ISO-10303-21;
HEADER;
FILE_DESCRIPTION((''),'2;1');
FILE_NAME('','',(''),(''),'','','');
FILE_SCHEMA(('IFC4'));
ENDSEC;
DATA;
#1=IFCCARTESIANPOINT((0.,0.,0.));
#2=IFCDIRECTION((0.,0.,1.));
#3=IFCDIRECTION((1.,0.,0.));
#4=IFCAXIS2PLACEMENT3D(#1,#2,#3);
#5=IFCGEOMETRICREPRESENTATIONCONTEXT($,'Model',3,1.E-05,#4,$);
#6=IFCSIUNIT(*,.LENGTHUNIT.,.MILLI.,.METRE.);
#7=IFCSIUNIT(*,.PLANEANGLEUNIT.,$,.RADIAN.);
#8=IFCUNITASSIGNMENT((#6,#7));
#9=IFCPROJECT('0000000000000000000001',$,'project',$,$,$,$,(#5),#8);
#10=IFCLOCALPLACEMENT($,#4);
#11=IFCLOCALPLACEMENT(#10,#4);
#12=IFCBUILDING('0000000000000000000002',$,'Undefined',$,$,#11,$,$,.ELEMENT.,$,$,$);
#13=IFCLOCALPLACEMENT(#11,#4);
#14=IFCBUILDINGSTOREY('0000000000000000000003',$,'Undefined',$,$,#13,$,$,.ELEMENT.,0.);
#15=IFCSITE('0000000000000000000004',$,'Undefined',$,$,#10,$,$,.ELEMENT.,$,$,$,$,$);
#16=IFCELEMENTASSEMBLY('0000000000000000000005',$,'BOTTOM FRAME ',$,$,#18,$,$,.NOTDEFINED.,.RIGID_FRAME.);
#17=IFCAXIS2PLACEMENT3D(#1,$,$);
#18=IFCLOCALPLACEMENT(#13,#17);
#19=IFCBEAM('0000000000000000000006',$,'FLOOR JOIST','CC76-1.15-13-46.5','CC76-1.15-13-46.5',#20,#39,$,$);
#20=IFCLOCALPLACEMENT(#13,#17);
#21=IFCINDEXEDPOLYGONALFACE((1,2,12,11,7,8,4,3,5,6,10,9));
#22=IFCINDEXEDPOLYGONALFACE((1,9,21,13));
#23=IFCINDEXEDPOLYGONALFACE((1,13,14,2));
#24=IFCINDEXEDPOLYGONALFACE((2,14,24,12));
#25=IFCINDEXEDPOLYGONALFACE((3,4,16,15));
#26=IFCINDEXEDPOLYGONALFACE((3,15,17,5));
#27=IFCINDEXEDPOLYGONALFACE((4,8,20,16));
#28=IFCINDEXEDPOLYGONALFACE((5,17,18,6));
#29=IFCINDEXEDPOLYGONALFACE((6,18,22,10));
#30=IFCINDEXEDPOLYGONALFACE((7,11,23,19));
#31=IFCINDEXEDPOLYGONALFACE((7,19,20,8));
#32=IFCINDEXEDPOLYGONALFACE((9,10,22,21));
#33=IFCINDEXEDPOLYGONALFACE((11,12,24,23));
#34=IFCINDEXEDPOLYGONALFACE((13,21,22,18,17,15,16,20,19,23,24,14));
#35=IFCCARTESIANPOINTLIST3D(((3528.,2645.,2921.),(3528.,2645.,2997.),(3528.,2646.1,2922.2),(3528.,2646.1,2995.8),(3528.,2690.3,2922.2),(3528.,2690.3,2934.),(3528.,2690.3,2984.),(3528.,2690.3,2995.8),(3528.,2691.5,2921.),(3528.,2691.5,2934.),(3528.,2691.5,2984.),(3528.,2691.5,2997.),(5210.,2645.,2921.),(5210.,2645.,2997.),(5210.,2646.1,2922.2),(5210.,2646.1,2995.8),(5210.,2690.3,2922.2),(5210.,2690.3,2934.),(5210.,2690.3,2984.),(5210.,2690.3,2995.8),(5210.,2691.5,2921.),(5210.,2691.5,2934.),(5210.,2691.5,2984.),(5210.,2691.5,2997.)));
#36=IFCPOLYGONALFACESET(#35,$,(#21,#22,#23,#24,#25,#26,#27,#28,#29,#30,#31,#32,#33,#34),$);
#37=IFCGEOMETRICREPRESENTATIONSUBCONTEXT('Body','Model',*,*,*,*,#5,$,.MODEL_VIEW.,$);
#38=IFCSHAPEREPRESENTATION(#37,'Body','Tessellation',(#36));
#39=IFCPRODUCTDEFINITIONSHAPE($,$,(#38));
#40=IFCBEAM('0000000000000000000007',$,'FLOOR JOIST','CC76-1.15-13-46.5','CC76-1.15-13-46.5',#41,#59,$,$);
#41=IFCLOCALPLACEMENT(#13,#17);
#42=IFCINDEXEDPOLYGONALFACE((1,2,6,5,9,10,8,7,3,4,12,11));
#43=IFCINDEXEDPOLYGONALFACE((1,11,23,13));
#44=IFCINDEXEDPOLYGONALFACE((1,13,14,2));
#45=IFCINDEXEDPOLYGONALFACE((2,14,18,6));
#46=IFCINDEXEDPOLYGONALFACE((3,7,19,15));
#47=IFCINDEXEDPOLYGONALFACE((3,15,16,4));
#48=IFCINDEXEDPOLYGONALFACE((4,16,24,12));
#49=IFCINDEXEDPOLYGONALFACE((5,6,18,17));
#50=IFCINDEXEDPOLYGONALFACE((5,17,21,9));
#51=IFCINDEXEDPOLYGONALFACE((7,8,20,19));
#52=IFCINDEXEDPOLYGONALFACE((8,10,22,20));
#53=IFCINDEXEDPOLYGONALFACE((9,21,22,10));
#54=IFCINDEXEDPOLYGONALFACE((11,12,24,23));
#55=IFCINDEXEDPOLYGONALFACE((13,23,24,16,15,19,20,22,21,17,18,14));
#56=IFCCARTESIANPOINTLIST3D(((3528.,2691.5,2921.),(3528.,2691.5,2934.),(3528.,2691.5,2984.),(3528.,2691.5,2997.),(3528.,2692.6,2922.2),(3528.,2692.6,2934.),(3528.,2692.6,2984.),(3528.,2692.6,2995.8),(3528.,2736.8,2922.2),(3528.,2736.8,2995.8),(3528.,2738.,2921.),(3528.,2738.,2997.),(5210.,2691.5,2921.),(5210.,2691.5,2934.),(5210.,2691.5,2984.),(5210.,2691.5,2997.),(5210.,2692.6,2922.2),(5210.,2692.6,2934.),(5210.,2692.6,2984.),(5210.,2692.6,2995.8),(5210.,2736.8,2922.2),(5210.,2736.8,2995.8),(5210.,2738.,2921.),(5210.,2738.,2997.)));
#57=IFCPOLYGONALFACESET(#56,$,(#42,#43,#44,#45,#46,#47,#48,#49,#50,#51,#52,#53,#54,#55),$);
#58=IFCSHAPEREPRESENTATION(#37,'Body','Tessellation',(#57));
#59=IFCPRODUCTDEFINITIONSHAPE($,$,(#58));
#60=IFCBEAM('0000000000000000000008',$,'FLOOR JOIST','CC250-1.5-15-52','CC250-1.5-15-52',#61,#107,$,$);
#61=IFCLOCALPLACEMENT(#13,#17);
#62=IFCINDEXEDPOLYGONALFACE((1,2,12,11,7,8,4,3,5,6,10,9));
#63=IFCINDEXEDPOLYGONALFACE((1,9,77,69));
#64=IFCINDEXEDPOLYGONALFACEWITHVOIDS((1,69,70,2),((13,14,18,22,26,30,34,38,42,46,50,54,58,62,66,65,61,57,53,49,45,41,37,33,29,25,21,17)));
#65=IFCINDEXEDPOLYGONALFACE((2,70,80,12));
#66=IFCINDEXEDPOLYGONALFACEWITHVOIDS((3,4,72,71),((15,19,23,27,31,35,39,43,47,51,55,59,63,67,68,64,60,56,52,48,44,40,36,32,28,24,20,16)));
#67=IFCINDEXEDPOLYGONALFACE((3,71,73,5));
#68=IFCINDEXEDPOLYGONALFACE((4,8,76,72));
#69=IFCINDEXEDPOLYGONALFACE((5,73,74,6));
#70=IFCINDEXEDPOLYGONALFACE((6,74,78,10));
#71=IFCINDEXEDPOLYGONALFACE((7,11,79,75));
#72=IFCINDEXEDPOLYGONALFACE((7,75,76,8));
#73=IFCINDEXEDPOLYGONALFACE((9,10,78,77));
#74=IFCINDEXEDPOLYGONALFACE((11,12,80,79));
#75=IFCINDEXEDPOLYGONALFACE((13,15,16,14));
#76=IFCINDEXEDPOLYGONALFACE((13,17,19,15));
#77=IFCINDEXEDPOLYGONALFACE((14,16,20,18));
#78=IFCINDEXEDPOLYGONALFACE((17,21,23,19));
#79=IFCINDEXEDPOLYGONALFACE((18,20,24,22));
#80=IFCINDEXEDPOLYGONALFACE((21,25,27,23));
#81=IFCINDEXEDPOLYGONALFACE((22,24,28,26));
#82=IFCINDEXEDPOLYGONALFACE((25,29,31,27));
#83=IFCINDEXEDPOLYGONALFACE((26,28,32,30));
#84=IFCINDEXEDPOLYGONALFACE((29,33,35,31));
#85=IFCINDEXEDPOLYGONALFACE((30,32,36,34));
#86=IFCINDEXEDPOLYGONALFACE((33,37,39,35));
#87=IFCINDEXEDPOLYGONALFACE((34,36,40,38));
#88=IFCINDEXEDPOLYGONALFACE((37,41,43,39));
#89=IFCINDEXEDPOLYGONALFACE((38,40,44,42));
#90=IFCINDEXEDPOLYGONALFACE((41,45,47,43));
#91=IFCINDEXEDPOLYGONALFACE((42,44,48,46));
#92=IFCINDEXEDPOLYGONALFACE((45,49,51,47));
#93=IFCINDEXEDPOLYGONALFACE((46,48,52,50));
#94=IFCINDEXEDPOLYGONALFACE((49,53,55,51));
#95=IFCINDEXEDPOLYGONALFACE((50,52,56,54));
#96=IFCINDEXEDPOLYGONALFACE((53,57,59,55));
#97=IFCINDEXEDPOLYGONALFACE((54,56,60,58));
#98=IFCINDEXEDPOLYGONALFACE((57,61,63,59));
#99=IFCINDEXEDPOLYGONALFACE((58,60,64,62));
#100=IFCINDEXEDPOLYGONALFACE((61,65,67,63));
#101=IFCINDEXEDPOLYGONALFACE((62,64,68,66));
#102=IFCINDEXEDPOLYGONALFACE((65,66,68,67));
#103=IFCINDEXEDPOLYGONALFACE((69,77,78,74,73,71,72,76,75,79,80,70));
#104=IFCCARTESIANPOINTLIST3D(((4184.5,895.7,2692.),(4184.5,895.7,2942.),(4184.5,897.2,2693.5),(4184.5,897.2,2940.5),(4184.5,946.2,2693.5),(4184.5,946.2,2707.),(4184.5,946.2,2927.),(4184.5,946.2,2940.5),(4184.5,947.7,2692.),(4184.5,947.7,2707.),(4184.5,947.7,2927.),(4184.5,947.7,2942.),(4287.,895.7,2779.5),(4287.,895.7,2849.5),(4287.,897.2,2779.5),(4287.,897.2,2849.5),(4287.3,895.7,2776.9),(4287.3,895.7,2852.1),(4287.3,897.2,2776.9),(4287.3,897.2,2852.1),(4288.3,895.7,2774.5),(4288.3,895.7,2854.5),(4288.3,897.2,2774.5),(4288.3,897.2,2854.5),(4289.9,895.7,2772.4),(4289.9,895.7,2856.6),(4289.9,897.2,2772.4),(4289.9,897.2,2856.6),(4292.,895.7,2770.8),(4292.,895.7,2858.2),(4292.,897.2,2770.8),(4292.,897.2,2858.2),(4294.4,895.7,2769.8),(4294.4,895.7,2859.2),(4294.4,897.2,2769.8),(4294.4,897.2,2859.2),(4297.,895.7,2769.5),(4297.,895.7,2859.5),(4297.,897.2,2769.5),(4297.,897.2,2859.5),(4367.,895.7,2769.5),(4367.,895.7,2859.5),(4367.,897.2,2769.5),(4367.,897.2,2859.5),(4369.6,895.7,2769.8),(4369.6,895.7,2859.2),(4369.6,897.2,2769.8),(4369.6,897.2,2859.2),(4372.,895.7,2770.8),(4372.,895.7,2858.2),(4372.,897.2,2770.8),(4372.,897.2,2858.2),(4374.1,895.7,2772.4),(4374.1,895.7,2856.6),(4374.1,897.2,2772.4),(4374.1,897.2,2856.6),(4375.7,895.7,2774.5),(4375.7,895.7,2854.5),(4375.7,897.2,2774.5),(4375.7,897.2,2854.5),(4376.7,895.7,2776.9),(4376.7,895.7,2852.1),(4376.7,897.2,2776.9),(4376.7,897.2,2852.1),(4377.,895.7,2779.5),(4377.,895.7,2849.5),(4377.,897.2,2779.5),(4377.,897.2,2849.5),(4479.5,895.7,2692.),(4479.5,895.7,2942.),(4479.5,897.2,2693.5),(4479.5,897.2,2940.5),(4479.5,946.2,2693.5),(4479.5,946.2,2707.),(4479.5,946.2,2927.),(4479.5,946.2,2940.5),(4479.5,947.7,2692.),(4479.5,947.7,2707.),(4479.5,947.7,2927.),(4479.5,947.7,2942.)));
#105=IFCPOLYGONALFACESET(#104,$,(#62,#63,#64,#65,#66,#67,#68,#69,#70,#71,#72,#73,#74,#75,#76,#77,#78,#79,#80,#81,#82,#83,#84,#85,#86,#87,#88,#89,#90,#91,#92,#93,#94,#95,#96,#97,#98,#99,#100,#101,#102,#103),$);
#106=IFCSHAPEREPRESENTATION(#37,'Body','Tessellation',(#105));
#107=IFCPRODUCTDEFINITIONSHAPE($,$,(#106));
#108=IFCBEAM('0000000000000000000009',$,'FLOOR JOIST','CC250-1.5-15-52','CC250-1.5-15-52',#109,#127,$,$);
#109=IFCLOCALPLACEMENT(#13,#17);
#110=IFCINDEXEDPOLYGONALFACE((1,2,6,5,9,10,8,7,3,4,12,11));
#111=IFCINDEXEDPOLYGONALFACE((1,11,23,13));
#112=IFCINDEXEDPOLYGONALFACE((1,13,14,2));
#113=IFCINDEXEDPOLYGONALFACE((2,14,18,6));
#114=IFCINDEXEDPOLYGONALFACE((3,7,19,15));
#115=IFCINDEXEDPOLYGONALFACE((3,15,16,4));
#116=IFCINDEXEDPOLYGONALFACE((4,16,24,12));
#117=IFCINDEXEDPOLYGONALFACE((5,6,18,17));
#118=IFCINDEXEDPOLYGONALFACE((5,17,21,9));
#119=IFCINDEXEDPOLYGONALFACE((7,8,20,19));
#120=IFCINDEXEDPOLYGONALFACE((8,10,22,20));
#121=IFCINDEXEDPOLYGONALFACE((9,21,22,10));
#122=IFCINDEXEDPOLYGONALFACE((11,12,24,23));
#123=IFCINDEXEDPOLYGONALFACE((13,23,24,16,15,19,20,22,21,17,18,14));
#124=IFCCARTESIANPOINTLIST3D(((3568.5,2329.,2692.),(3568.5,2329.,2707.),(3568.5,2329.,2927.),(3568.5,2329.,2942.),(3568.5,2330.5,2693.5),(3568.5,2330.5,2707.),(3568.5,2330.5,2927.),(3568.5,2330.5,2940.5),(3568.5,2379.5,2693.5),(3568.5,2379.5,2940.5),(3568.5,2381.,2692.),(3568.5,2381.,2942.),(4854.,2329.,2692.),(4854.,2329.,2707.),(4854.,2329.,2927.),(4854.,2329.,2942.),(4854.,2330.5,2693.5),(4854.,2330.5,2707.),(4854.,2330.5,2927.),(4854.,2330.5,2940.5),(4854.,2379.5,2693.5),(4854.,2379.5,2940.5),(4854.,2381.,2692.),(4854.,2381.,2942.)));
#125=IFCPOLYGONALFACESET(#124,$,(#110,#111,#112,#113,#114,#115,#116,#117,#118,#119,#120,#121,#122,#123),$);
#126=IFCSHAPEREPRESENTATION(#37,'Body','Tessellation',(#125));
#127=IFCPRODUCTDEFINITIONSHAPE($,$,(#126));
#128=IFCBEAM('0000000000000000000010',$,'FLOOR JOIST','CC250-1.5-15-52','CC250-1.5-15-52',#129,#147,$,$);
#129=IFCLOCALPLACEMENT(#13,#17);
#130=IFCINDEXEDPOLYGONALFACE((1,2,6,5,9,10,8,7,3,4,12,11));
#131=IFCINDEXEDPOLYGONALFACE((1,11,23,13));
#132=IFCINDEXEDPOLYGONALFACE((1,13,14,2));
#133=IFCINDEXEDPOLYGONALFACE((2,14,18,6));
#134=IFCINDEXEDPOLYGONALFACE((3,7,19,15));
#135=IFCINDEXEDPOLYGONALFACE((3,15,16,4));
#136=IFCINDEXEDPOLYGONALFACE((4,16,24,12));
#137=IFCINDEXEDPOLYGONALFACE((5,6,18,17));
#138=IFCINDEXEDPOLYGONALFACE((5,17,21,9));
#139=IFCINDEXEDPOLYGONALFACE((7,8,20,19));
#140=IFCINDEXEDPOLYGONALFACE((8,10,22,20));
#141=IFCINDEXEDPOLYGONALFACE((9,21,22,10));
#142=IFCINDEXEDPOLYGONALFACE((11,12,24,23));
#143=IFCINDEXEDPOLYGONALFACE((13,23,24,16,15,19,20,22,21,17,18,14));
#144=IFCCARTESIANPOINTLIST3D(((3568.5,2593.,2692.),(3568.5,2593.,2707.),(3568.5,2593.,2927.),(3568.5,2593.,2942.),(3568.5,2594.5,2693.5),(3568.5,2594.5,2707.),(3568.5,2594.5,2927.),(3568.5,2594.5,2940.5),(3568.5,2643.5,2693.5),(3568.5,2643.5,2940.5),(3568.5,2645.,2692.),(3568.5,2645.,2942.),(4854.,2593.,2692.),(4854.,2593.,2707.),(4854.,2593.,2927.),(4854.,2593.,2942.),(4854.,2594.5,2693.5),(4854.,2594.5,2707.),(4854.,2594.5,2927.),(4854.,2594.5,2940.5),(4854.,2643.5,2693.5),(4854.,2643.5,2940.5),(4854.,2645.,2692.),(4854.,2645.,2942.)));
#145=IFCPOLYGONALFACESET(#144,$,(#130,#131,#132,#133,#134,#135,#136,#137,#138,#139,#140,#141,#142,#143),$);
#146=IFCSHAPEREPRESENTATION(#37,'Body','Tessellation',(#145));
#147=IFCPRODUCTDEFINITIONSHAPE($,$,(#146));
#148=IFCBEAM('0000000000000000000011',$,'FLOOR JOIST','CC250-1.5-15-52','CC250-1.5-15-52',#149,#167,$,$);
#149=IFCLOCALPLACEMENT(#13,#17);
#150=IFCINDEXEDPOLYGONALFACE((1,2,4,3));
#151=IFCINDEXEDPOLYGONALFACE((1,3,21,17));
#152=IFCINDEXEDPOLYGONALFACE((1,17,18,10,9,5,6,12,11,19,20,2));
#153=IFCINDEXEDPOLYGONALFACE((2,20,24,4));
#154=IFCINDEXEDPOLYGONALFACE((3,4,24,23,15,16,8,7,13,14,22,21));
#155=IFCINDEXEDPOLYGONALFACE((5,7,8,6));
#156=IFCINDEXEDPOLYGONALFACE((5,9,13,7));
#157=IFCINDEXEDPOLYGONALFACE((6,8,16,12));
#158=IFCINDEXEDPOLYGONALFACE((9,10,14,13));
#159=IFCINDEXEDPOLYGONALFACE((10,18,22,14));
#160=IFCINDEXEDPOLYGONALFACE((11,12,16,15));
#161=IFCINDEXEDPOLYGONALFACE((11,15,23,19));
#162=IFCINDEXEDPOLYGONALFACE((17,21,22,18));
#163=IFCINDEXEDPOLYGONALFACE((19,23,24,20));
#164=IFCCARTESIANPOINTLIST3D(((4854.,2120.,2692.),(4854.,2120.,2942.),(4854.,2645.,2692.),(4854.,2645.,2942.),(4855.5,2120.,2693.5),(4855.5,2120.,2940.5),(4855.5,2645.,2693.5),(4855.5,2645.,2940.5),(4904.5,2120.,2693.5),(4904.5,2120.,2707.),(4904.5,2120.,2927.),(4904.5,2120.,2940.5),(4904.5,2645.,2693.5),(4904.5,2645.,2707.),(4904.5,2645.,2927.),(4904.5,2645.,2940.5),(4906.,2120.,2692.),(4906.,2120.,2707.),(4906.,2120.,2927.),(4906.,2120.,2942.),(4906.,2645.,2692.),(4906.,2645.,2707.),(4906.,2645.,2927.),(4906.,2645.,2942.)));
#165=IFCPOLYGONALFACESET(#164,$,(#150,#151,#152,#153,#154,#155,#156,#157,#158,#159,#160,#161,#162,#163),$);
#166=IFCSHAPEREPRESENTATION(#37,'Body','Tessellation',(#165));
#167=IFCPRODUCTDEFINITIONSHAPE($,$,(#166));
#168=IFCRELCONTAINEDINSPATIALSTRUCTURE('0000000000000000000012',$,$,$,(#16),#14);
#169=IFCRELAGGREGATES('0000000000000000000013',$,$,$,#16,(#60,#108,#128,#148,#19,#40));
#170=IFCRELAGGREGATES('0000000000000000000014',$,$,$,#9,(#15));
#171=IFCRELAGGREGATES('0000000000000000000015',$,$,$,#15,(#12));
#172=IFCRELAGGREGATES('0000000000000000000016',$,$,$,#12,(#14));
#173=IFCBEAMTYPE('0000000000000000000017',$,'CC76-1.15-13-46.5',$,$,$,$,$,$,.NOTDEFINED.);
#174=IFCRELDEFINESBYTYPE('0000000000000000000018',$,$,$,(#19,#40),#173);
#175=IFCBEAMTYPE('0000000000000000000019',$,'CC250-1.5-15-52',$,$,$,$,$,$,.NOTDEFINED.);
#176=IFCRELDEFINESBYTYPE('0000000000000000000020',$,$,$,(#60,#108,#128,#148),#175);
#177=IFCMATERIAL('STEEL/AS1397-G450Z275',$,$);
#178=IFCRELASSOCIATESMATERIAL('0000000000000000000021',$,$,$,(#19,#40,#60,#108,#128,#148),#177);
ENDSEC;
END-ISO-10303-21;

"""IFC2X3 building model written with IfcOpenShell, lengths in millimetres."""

from ifc_helpers import new_model, si_unit, frame, frame_2d, origin_with_axes, origin_2d_with_axis, place, context, subcontext, project, spatial, polyline, circle_curve, parameter, trimmed, segment, composite_curve, c_section, outline, extrude, boolean, material, type_object, element, aggregate, save


model = new_model("IFC2X3")

# Units and contexts
model_context = context("Model", 3, precision=1e-05, world=origin_with_axes())
body_context = subcontext(model_context, "Body", "Model", "MODEL_VIEW")
ifc_project = project(units=[si_unit("LENGTHUNIT", "METRE", prefix="MILLI"), si_unit("PLANEANGLEUNIT", "RADIAN")], contexts=[model_context])

# Site, building, storey
site_placement = place(None, origin_with_axes())
site = spatial("IfcSite", under=ifc_project, at=site_placement, Name="Undefined", CompositionType="ELEMENT")
building_placement = place(site_placement, origin_with_axes())
building = spatial("IfcBuilding", under=site, at=building_placement, Name="Undefined", CompositionType="ELEMENT")
storey_placement = place(building_placement, origin_with_axes())
storey = spatial("IfcBuildingStorey", under=building, at=storey_placement, Name="Undefined", CompositionType="ELEMENT", Elevation=0.0)

# Element assembly, beams
assembly_1_placement = place(storey_placement, origin_with_axes())
assembly_1 = element("IfcElementAssembly", 1, at=assembly_1_placement, inside=storey, Name="BOTTOM FRAME ", AssemblyPlace="NOTDEFINED", PredefinedType="RIGID_FRAME")
ifc_material_1 = material(Name="STEEL/AS1397-G450Z275")
beam_type_1 = type_object("IfcBeamType", Name="CC76-1.15-13-46.5", PredefinedType="NOTDEFINED")
beam_1_placement = place(assembly_1_placement, frame((3528.0, 2668.2, 2959.0), z_axis=(0.0, 0.0, -1.0), x_axis=(1.0, 0.0, 0.0)))
beam_1 = element("IfcBeam", 2, at=beam_1_placement, type_object=beam_type_1, material=ifc_material_1, Name="FLOOR JOIST", Description="CC76-1.15-13-46.5", ObjectType="CC76-1.15-13-46.5", context=body_context, shape_type="SweptSolid", body=[
    extrude(c_section(Depth=76.0, Width=46.5, WallThickness=1.1, Girth=13.0, at=origin_2d_with_axis()), frame((1682.0, 0.0, 0.0), z_axis=(-1.0, 0.0, 0.0), x_axis=(0.0, -1.0, 0.0)), (0.0, 0.0, 1.0), 1682.0),
])
beam_2_placement = place(assembly_1_placement, frame((3528.0, 2714.7, 2959.0), z_axis=(0.0, 0.0, 1.0), x_axis=(1.0, 0.0, 0.0)))
beam_2 = element("IfcBeam", 3, at=beam_2_placement, type_object=beam_type_1, material=ifc_material_1, Name="FLOOR JOIST", Description="CC76-1.15-13-46.5", ObjectType="CC76-1.15-13-46.5", context=body_context, shape_type="SweptSolid", body=[
    extrude(c_section(Depth=76.0, Width=46.5, WallThickness=1.1, Girth=13.0, at=origin_2d_with_axis()), frame((1682.0, 0.0, 0.0), z_axis=(-1.0, 0.0, 0.0), x_axis=(0.0, -1.0, 0.0)), (0.0, 0.0, 1.0), 1682.0),
])
beam_type_2 = type_object("IfcBeamType", Name="CC250-1.5-15-52", PredefinedType="NOTDEFINED")
beam_3_placement = place(assembly_1_placement, frame((4184.5, 921.7, 2817.0), z_axis=(0.0, 0.0, -1.0), x_axis=(1.0, 0.0, 0.0)))
beam_3 = element("IfcBeam", 4, at=beam_3_placement, type_object=beam_type_2, material=ifc_material_1, Name="FLOOR JOIST", Description="CC250-1.5-15-52", ObjectType="CC250-1.5-15-52", context=body_context, shape_type="CSG", body=[
    boolean("DIFFERENCE", extrude(c_section(Depth=250.0, Width=52.0, WallThickness=1.5, Girth=15.0, at=origin_2d_with_axis()), frame((295.0, 0.0, 0.0), z_axis=(-1.0, 0.0, 0.0), x_axis=(0.0, -1.0, 0.0)), (0.0, 0.0, 1.0), 295.0), extrude(outline(composite_curve([segment(trimmed(circle_curve(frame_2d((10.0, 10.0), x_axis=(-1.0, 0.0)), 10.0), [parameter(0.0)], [parameter(1.570796)], True, "PARAMETER"), True, "CONTINUOUS"), segment(polyline([(10.0, 0.0), (80.0, 0.0)]), True, "CONTINUOUS"), segment(trimmed(circle_curve(frame_2d((80.0, 10.0), x_axis=(0.0, -1.0)), 10.0), [parameter(0.0)], [parameter(1.570796)], True, "PARAMETER"), True, "CONTINUOUS"), segment(polyline([(90.0, 10.0), (90.0, 80.0)]), True, "CONTINUOUS"), segment(trimmed(circle_curve(frame_2d((80.0, 80.0), x_axis=(1.0, 0.0)), 10.0), [parameter(0.0)], [parameter(1.570796)], True, "PARAMETER"), True, "CONTINUOUS"), segment(polyline([(80.0, 90.0), (10.0, 90.0)]), True, "CONTINUOUS"), segment(trimmed(circle_curve(frame_2d((10.0, 80.0), x_axis=(0.0, 1.0)), 10.0), [parameter(0.0)], [parameter(1.570796)], True, "PARAMETER"), True, "CONTINUOUS"), segment(polyline([(0.0, 80.0), (0.0, 10.0)]), True, "CONTINUOUS")], self_intersect=True)), frame((102.5, 40.5, -42.5), z_axis=(0.0, -1.0, 0.0), x_axis=(1.0, 0.0, 0.0)), (0.0, 0.0, 1.0), 81.0)),
])
beam_4_placement = place(assembly_1_placement, frame((3568.5, 2355.0, 2817.0), z_axis=(0.0, 0.0, 1.0), x_axis=(1.0, 0.0, 0.0)))
beam_4 = element("IfcBeam", 5, at=beam_4_placement, type_object=beam_type_2, material=ifc_material_1, Name="FLOOR JOIST", Description="CC250-1.5-15-52", ObjectType="CC250-1.5-15-52", context=body_context, shape_type="SweptSolid", body=[
    extrude(c_section(Depth=250.0, Width=52.0, WallThickness=1.5, Girth=15.0, at=origin_2d_with_axis()), frame((1285.5, 0.0, 0.0), z_axis=(-1.0, 0.0, 0.0), x_axis=(0.0, -1.0, 0.0)), (0.0, 0.0, 1.0), 1285.5),
])
beam_5_placement = place(assembly_1_placement, frame((3568.5, 2619.0, 2817.0), z_axis=(0.0, 0.0, 1.0), x_axis=(1.0, 0.0, 0.0)))
beam_5 = element("IfcBeam", 6, at=beam_5_placement, type_object=beam_type_2, material=ifc_material_1, Name="FLOOR JOIST", Description="CC250-1.5-15-52", ObjectType="CC250-1.5-15-52", context=body_context, shape_type="SweptSolid", body=[
    extrude(c_section(Depth=250.0, Width=52.0, WallThickness=1.5, Girth=15.0, at=origin_2d_with_axis()), frame((1285.5, 0.0, 0.0), z_axis=(-1.0, 0.0, 0.0), x_axis=(0.0, -1.0, 0.0)), (0.0, 0.0, 1.0), 1285.5),
])
beam_6_placement = place(assembly_1_placement, frame((4880.0, 2645.0, 2817.0), z_axis=(0.0, 0.0, -1.0), x_axis=(0.0, -1.0, 0.0)))
beam_6 = element("IfcBeam", 7, at=beam_6_placement, type_object=beam_type_2, material=ifc_material_1, Name="FLOOR JOIST", Description="CC250-1.5-15-52", ObjectType="CC250-1.5-15-52", context=body_context, shape_type="SweptSolid", body=[
    extrude(c_section(Depth=250.0, Width=52.0, WallThickness=1.5, Girth=15.0, at=origin_2d_with_axis()), frame((525.0, 0.0, 0.0), z_axis=(-1.0, 0.0, 0.0), x_axis=(0.0, -1.0, 0.0)), (0.0, 0.0, 1.0), 525.0),
])

aggregate(assembly_1, [beam_3, beam_4, beam_5, beam_6, beam_1, beam_2])

save(model, "model.ifc")
